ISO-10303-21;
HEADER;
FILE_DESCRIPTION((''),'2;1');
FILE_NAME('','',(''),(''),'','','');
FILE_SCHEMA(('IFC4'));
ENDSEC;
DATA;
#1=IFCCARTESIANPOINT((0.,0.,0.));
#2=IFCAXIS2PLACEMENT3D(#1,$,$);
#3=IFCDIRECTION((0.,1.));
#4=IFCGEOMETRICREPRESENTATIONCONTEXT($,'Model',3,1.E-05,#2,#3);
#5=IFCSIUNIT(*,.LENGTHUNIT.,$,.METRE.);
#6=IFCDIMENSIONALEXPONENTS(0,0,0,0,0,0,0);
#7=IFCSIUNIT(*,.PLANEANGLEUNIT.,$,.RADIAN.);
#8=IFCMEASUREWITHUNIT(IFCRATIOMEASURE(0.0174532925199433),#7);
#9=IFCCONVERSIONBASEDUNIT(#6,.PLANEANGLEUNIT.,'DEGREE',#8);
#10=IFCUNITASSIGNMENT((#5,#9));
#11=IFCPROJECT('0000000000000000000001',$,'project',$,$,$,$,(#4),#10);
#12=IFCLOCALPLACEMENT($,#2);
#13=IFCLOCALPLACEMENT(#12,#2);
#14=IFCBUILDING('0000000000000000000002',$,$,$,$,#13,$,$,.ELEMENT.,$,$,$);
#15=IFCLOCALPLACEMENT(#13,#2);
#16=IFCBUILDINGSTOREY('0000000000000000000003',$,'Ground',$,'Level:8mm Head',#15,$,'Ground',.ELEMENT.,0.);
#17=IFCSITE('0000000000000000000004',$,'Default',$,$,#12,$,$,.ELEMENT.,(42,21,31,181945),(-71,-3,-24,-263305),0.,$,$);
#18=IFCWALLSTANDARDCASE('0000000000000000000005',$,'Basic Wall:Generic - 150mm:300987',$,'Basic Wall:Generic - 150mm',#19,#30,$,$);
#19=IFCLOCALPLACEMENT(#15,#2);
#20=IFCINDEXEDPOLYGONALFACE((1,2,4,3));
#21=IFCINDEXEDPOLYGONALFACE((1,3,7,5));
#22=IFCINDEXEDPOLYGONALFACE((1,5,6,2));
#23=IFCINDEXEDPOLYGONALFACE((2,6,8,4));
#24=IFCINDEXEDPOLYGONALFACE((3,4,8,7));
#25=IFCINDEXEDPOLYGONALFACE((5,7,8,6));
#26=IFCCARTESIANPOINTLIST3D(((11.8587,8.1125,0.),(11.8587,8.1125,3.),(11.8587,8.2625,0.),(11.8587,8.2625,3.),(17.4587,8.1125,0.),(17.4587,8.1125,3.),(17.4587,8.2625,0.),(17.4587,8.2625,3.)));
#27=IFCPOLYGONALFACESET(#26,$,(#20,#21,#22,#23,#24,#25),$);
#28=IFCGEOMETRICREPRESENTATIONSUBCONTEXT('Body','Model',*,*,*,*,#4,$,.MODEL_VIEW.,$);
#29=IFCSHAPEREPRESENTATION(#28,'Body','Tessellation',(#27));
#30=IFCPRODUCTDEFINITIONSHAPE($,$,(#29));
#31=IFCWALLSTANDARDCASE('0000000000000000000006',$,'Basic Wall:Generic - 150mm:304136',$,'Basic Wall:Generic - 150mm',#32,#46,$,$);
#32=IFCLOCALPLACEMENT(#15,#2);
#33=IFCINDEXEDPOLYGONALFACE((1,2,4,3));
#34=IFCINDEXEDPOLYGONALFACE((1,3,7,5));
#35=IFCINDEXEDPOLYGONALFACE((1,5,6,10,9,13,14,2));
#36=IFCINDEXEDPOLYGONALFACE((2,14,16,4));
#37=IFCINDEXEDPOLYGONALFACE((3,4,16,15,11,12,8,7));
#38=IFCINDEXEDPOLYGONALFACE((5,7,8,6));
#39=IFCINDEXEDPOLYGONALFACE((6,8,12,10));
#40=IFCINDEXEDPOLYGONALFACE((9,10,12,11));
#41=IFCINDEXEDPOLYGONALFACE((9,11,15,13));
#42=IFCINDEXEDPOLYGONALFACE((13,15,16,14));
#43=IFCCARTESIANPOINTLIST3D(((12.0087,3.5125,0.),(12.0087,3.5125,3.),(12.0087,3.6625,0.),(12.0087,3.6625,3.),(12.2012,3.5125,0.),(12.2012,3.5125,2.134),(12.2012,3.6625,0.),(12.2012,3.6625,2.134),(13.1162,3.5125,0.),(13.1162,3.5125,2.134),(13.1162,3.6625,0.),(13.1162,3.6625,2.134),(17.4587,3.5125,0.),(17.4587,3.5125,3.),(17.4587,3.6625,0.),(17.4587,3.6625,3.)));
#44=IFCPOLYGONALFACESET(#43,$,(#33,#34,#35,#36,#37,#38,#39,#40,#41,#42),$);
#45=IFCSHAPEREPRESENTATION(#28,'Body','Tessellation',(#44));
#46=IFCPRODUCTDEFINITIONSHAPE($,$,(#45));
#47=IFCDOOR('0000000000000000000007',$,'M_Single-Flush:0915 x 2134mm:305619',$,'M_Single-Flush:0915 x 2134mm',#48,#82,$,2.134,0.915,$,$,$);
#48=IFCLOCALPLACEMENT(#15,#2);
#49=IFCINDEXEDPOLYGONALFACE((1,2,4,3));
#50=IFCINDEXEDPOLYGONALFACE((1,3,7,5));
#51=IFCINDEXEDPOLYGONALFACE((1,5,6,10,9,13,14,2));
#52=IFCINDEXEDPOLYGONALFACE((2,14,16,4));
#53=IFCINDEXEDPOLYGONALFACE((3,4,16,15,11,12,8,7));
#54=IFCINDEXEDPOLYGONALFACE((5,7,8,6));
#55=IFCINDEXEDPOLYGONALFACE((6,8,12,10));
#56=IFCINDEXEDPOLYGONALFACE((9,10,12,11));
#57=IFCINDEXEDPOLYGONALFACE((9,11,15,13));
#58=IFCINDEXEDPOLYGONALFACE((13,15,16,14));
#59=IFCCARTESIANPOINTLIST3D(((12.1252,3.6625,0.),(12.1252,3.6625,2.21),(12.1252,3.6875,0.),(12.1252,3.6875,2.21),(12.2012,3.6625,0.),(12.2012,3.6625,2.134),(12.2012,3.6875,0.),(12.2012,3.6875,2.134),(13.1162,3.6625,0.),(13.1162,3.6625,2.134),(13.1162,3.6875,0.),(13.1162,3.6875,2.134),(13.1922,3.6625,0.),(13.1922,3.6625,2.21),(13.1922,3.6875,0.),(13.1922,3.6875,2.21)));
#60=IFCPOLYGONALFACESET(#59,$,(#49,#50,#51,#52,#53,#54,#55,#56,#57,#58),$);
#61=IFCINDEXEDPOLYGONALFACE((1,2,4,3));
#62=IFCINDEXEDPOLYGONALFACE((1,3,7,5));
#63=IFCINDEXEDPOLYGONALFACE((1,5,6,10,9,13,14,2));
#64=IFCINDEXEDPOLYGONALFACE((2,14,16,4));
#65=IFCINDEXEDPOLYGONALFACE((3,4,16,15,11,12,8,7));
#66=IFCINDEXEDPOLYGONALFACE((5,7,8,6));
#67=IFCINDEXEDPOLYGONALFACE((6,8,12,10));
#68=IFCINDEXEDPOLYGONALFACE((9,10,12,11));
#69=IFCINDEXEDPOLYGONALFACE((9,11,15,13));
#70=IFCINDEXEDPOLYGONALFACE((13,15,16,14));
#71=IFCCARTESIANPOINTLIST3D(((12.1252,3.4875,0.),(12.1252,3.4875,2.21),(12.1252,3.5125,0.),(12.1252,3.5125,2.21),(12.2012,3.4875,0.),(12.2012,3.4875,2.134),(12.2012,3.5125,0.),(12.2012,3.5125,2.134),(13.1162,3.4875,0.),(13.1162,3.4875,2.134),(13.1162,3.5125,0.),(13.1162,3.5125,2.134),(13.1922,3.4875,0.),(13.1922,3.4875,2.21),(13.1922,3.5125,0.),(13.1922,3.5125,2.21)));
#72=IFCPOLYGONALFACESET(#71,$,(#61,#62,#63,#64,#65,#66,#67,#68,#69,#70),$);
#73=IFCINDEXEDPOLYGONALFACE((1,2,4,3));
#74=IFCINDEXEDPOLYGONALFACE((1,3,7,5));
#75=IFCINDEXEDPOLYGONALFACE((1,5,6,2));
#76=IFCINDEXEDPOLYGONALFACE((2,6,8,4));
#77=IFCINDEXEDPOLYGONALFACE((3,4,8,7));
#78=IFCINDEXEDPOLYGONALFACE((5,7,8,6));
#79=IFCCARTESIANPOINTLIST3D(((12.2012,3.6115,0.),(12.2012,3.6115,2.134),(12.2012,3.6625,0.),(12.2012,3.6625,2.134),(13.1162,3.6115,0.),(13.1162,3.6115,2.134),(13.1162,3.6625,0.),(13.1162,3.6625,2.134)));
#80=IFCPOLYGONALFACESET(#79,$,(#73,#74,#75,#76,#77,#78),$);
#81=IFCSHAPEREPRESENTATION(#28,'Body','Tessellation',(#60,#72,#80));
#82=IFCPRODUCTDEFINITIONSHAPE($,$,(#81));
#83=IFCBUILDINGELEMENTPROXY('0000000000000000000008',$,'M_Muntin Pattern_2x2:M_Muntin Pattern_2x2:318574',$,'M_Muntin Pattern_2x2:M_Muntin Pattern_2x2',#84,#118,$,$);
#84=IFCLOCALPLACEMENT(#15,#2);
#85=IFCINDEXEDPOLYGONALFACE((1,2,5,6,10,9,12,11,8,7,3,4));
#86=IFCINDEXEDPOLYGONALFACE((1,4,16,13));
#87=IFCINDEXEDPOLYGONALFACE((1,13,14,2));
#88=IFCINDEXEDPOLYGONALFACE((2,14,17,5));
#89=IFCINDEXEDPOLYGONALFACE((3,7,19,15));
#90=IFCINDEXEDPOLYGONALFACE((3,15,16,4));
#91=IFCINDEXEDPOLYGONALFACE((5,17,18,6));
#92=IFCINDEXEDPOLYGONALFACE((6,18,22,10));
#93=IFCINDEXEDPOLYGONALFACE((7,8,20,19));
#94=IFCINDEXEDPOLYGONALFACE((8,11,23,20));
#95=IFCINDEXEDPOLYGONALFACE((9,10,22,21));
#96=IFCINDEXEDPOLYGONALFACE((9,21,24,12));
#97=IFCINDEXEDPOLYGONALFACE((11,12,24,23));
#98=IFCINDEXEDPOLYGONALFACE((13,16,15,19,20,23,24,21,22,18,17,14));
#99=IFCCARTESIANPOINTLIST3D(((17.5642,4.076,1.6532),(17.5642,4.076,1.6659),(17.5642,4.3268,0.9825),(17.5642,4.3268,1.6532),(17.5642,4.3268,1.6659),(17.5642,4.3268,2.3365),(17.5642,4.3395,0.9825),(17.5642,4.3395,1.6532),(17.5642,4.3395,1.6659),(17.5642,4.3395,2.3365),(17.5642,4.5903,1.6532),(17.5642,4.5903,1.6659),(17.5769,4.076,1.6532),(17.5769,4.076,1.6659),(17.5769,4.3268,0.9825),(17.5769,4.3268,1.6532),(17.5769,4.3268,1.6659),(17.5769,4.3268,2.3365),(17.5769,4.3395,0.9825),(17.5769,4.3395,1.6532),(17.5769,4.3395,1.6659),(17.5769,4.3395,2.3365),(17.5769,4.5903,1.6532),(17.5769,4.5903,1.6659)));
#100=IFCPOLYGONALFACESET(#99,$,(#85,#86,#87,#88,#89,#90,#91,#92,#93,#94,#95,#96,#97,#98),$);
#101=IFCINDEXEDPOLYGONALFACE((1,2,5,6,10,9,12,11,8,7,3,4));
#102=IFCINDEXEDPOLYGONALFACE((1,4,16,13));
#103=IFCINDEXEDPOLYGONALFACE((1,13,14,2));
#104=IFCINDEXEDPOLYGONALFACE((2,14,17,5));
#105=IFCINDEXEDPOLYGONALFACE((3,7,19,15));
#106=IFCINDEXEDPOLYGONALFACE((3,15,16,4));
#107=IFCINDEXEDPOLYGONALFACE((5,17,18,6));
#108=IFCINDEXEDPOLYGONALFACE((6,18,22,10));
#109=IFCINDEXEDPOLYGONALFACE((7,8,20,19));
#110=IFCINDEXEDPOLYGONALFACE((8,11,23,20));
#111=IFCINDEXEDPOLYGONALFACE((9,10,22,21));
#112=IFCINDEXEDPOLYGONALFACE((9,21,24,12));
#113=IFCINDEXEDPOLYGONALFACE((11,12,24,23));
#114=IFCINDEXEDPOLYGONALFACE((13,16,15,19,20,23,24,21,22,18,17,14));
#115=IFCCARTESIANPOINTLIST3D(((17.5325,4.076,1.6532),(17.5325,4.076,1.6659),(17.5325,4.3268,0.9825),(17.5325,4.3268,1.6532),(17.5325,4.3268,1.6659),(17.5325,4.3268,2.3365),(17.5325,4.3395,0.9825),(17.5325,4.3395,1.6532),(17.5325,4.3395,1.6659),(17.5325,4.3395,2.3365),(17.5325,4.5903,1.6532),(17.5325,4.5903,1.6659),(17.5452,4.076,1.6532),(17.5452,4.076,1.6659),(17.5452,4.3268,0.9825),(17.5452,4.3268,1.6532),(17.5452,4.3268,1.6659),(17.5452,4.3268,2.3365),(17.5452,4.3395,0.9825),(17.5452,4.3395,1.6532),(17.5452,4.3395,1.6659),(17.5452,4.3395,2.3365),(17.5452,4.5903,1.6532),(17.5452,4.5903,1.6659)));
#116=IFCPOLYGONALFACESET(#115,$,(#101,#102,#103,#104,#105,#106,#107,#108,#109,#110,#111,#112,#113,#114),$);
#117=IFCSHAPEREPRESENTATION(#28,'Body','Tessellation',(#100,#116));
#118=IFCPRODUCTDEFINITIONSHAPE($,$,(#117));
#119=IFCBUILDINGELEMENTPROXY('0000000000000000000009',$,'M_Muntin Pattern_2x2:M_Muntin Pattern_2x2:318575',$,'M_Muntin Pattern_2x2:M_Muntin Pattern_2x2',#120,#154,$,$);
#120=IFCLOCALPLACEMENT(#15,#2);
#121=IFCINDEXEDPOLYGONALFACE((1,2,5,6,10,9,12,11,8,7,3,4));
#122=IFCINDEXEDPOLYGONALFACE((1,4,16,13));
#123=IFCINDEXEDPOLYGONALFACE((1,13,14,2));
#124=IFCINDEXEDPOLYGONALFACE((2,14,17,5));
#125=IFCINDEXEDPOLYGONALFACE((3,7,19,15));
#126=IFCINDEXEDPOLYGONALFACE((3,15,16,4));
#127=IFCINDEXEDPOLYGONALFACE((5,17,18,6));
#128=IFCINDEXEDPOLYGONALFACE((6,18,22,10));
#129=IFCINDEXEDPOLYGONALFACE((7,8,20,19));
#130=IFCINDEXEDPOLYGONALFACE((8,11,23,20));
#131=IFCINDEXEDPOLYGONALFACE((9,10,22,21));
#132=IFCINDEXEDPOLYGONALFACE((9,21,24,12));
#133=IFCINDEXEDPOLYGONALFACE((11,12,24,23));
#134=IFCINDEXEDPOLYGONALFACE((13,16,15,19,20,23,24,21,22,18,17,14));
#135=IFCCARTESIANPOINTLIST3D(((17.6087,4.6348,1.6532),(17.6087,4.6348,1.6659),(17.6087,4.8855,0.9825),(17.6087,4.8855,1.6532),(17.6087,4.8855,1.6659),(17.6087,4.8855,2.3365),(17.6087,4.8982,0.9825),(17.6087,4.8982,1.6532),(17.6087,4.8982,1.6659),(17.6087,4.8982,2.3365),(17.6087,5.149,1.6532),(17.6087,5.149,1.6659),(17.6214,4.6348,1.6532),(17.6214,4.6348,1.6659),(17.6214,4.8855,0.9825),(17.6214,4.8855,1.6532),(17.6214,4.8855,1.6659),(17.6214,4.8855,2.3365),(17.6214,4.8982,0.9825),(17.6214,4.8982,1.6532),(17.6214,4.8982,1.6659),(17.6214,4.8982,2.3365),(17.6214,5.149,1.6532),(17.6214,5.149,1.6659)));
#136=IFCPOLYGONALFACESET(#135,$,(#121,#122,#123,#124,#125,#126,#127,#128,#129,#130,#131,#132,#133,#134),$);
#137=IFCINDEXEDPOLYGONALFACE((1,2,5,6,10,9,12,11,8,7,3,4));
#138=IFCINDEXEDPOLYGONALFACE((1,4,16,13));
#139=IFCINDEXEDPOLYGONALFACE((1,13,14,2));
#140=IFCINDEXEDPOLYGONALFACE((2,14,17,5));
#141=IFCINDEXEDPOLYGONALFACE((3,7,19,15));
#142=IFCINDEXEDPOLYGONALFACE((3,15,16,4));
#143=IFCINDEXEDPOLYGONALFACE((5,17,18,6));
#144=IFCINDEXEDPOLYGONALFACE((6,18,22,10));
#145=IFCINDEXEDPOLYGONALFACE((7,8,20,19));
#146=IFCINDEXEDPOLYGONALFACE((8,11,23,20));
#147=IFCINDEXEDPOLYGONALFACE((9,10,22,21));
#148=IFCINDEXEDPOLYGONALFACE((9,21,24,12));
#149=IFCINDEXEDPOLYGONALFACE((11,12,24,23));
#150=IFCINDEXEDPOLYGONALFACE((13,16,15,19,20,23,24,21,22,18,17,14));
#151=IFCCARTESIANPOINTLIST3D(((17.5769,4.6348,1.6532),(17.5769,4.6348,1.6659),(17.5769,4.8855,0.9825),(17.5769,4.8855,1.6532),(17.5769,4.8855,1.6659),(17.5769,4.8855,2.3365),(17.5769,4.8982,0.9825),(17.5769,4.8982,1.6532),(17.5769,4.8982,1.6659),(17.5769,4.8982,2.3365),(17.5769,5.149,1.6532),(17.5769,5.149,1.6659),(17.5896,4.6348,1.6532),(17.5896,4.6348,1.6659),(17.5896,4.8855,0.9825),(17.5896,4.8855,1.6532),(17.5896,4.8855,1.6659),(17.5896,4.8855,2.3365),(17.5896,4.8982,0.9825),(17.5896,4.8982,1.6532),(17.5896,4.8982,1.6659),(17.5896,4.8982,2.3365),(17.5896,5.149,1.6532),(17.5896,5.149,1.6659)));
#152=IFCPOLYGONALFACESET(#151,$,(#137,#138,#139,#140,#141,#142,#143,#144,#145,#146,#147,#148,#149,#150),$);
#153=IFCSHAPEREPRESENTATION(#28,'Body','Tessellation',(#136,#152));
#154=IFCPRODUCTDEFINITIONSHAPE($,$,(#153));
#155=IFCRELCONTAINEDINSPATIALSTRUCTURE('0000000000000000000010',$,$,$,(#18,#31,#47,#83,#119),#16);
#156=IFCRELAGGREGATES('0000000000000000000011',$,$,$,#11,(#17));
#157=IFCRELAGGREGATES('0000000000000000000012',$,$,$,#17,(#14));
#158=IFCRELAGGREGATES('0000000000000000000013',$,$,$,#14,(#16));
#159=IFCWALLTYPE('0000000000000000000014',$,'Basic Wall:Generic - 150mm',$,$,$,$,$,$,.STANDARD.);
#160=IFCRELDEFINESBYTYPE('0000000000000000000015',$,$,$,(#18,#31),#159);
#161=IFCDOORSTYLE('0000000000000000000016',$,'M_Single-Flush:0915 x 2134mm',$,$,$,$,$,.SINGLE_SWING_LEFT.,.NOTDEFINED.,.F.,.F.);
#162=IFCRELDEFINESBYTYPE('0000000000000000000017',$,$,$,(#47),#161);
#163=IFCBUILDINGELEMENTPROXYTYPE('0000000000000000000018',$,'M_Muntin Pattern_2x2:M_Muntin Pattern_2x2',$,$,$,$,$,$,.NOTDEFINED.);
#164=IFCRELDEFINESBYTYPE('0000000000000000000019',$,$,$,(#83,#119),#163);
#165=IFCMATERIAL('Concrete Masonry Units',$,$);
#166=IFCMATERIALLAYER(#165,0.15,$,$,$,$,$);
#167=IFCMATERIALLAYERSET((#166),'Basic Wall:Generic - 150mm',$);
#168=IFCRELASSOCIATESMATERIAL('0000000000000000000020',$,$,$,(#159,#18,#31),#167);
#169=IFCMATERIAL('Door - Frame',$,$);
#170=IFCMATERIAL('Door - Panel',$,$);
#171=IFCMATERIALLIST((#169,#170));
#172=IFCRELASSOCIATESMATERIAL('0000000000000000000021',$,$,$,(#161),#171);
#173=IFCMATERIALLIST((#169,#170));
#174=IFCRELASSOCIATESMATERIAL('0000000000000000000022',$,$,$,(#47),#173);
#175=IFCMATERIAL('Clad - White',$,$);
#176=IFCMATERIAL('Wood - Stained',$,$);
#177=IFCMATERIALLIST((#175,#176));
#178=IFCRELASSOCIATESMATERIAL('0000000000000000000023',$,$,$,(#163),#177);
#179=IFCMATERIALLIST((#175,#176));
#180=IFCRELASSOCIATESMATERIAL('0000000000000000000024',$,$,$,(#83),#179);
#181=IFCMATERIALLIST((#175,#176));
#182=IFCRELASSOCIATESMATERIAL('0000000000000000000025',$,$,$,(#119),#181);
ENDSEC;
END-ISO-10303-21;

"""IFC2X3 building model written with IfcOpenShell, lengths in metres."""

from ifc_helpers import new_model, entity, si_unit, converted_unit, direction, frame, frame_2d, origin, place, context, subcontext, project, spatial, polyline, rectangle, outline, extrude, source, transform, mapped, material, material_list, layer, layer_set, layer_usage, type_object, type_shapes, element, fill, save


model = new_model("IFC2X3")

# Units and contexts
model_context = context("Model", 3, precision=1e-05, world=origin(), true_north=direction((0.0, 1.0)))
body_context = subcontext(model_context, "Body", "Model", "MODEL_VIEW")
ifc_project = project(units=[si_unit("LENGTHUNIT", "METRE"), converted_unit("PLANEANGLEUNIT", "DEGREE", entity("IfcRatioMeasure", 0.0174532925199433), si_unit("PLANEANGLEUNIT", "RADIAN"), dimensions=[0, 0, 0, 0, 0, 0, 0])], contexts=[model_context])

# Site, building, storey
site_placement = place(None, origin())
site = spatial("IfcSite", under=ifc_project, at=site_placement, Name="Default", CompositionType="ELEMENT", RefLatitude=(42, 21, 31, 181945), RefLongitude=(-71, -3, -24, -263305), RefElevation=0.0)
building_placement = place(site_placement, origin())
building = spatial("IfcBuilding", under=site, at=building_placement, CompositionType="ELEMENT")
storey_placement = place(building_placement, origin())
storey = spatial("IfcBuildingStorey", under=building, at=storey_placement, Name="Ground", ObjectType="Level:8mm Head", LongName="Ground", CompositionType="ELEMENT", Elevation=0.0)

# Wall
ifc_material_1 = material(Name="Concrete Masonry Units")
ifc_layer = layer(ifc_material_1, 0.15)
ifc_layer_set = layer_set([ifc_layer], Name="Basic Wall:Generic - 150mm")
ifc_layer_usage_1 = layer_usage(ifc_layer_set, "AXIS2", "NEGATIVE", 0.075)
wall_type = type_object("IfcWallType", Name="Basic Wall:Generic - 150mm", PredefinedType="STANDARD", material=ifc_layer_set)
wall_1_placement = place(storey_placement, frame((17.4587, 8.1875, 0.0), z_axis=(0.0, 0.0, 1.0), x_axis=(-1.0, 0.0, 0.0)))
element("IfcWallStandardCase", 1, at=wall_1_placement, inside=storey, type_object=wall_type, material=ifc_layer_usage_1, Name="Basic Wall:Generic - 150mm:300987", ObjectType="Basic Wall:Generic - 150mm", context=body_context, shape_type="SweptSolid", body=[
    extrude(rectangle(XDim=5.6, YDim=0.15, at=frame_2d((2.8, 0.0), x_axis=(-1.0, 0.0))), origin(), (0.0, 0.0, 1.0), 3.0),
])

# Wall, opening, door
ifc_layer_usage_2 = layer_usage(ifc_layer_set, "AXIS2", "NEGATIVE", 0.075)
wall_2_placement = place(storey_placement, frame((17.4587, 3.5875, 0.0), z_axis=(0.0, 0.0, 1.0), x_axis=(-1.0, 0.0, 0.0)))
wall_2 = element("IfcWallStandardCase", 2, at=wall_2_placement, inside=storey, type_object=wall_type, material=ifc_layer_usage_2, Name="Basic Wall:Generic - 150mm:304136", ObjectType="Basic Wall:Generic - 150mm", context=body_context, shape_type="SweptSolid", body=[
    extrude(rectangle(XDim=5.45, YDim=0.15, at=frame_2d((2.725, 0.0), x_axis=(-1.0, 0.0))), origin(), (0.0, 0.0, 1.0), 3.0),
])
opening_placement = place(wall_2_placement, frame((5.2575, 0.075, 0.0)))
opening = element("IfcOpeningElement", 3, at=opening_placement, cuts=wall_2, ObjectType="Opening", context=body_context, shape_type="SweptSolid", body=[
    extrude(rectangle(XDim=0.915, YDim=2.134, at=frame_2d((1.067, 0.4575), x_axis=(0.0, -1.0))), frame((0.0, 0.0, 0.0), z_axis=(0.0, -1.0, 0.0), x_axis=(0.0, 0.0, 1.0)), (0.0, 0.0, 1.0), 0.15),
])
ifc_material_2 = material(Name="Door - Frame")
ifc_material_3 = material(Name="Door - Panel")
ifc_material_list_1 = material_list([ifc_material_2, ifc_material_3])
ifc_material_list_2 = material_list([ifc_material_2, ifc_material_3])
door_style = type_object("IfcDoorStyle", Name="M_Single-Flush:0915 x 2134mm", ConstructionType="NOTDEFINED", OperationType="SINGLE_SWING_LEFT", ParameterTakesPrecedence=False, Sizeable=False, material=ifc_material_list_2)
shared_shape_1 = source(origin(), body_context, "Body", "SweptSolid", [
    extrude(outline(polyline([(-0.5335, -1.124), (0.5335, -1.124), (0.5335, 1.086), (0.4575, 1.086), (0.4575, -1.048), (-0.4575, -1.048), (-0.4575, 1.086), (-0.5335, 1.086), (-0.5335, -1.124)])), frame((0.4575, 0.175, 1.086), z_axis=(0.0, -1.0, 0.0), x_axis=(-1.0, 0.0, 0.0)), (0.0, 0.0, 1.0), 0.025),
    extrude(outline(polyline([(-1.124, -0.5335), (1.086, -0.5335), (1.086, -0.4575), (-1.048, -0.4575), (-1.048, 0.4575), (1.086, 0.4575), (1.086, 0.5335), (-1.124, 0.5335), (-1.124, -0.5335)])), frame((0.4575, 0.0, 1.086), z_axis=(0.0, -1.0, 0.0), x_axis=(0.0, 0.0, -1.0)), (0.0, 0.0, 1.0), 0.025),
    extrude(rectangle(XDim=0.915, YDim=0.051, at=frame_2d((0.0, 0.0), x_axis=(1.0, 0.0))), frame((0.4575, 0.1245, 0.0)), (0.0, 0.0, 1.0), 2.134),
])
type_shapes(door_style, [shared_shape_1])
door_placement = place(opening_placement, frame((0.0, 0.0, 0.0), z_axis=(0.0, 0.0, 1.0), x_axis=(-1.0, 0.0, 0.0)))
door = element("IfcDoor", 4, at=door_placement, inside=storey, type_object=door_style, material=ifc_material_list_1, Name="M_Single-Flush:0915 x 2134mm:305619", ObjectType="M_Single-Flush:0915 x 2134mm", OverallHeight=2.134, OverallWidth=0.915, context=body_context, shape_type="MappedRepresentation", body=[
    mapped(shared_shape_1, transform((0.0, 0.0, 0.0), scale=1.0)),
])
fill(opening, door)

# Building element proxies
ifc_material_4 = material(Name="Clad - White")
ifc_material_5 = material(Name="Wood - Stained")
ifc_material_list_3 = material_list([ifc_material_4, ifc_material_5])
ifc_material_list_4 = material_list([ifc_material_4, ifc_material_5])
building_element_proxy_type_1 = type_object("IfcBuildingElementProxyType", Name="M_Muntin Pattern_2x2:M_Muntin Pattern_2x2", PredefinedType="NOTDEFINED", material=ifc_material_list_4)
shared_shape_2 = source(origin(), body_context, "Body", "SweptSolid", [
    extrude(outline(polyline([(0.0064, -0.0064), (0.677, -0.0064), (0.677, 0.0063), (0.0064, 0.0063), (0.0064, 0.2571), (-0.0063, 0.2571), (-0.0063, 0.0063), (-0.677, 0.0063), (-0.677, -0.0064), (-0.0063, -0.0064), (-0.0063, -0.2571), (0.0064, -0.2571), (0.0064, -0.0064)])), frame((0.0, 0.0095, 0.677), z_axis=(0.0, 1.0, 0.0), x_axis=(0.0, 0.0, 1.0)), (0.0, 0.0, 1.0), 0.0127),
    extrude(outline(polyline([(0.0064, -0.0064), (0.677, -0.0064), (0.677, 0.0063), (0.0064, 0.0063), (0.0064, 0.2571), (-0.0063, 0.2571), (-0.0063, 0.0063), (-0.677, 0.0063), (-0.677, -0.0064), (-0.0063, -0.0064), (-0.0063, -0.2571), (0.0064, -0.2571), (0.0064, -0.0064)])), frame((0.0, -0.0222, 0.677), z_axis=(0.0, 1.0, 0.0), x_axis=(0.0, 0.0, 1.0)), (0.0, 0.0, 1.0), 0.0127),
])
type_shapes(building_element_proxy_type_1, [shared_shape_2])
proxy_1_placement = place(storey_placement, frame((17.5547, 4.3332, 0.9825), z_axis=(0.0, 0.0, 1.0), x_axis=(0.0, -1.0, 0.0)))
element("IfcBuildingElementProxy", 5, at=proxy_1_placement, inside=storey, type_object=building_element_proxy_type_1, material=ifc_material_list_3, Name="M_Muntin Pattern_2x2:M_Muntin Pattern_2x2:318574", ObjectType="M_Muntin Pattern_2x2:M_Muntin Pattern_2x2", context=body_context, shape_type="MappedRepresentation", body=[
    mapped(shared_shape_2, transform((0.0, 0.0, 0.0), scale=1.0)),
])
ifc_material_list_5 = material_list([ifc_material_4, ifc_material_5])
proxy_2_placement = place(storey_placement, frame((17.5991, 4.8919, 0.9825), z_axis=(0.0, 0.0, 1.0), x_axis=(0.0, -1.0, 0.0)))
element("IfcBuildingElementProxy", 6, at=proxy_2_placement, inside=storey, type_object=building_element_proxy_type_1, material=ifc_material_list_5, Name="M_Muntin Pattern_2x2:M_Muntin Pattern_2x2:318575", ObjectType="M_Muntin Pattern_2x2:M_Muntin Pattern_2x2", context=body_context, shape_type="MappedRepresentation", body=[
    mapped(shared_shape_2, transform((0.0, 0.0, 0.0), scale=1.0)),
])

save(model, "model.ifc")
